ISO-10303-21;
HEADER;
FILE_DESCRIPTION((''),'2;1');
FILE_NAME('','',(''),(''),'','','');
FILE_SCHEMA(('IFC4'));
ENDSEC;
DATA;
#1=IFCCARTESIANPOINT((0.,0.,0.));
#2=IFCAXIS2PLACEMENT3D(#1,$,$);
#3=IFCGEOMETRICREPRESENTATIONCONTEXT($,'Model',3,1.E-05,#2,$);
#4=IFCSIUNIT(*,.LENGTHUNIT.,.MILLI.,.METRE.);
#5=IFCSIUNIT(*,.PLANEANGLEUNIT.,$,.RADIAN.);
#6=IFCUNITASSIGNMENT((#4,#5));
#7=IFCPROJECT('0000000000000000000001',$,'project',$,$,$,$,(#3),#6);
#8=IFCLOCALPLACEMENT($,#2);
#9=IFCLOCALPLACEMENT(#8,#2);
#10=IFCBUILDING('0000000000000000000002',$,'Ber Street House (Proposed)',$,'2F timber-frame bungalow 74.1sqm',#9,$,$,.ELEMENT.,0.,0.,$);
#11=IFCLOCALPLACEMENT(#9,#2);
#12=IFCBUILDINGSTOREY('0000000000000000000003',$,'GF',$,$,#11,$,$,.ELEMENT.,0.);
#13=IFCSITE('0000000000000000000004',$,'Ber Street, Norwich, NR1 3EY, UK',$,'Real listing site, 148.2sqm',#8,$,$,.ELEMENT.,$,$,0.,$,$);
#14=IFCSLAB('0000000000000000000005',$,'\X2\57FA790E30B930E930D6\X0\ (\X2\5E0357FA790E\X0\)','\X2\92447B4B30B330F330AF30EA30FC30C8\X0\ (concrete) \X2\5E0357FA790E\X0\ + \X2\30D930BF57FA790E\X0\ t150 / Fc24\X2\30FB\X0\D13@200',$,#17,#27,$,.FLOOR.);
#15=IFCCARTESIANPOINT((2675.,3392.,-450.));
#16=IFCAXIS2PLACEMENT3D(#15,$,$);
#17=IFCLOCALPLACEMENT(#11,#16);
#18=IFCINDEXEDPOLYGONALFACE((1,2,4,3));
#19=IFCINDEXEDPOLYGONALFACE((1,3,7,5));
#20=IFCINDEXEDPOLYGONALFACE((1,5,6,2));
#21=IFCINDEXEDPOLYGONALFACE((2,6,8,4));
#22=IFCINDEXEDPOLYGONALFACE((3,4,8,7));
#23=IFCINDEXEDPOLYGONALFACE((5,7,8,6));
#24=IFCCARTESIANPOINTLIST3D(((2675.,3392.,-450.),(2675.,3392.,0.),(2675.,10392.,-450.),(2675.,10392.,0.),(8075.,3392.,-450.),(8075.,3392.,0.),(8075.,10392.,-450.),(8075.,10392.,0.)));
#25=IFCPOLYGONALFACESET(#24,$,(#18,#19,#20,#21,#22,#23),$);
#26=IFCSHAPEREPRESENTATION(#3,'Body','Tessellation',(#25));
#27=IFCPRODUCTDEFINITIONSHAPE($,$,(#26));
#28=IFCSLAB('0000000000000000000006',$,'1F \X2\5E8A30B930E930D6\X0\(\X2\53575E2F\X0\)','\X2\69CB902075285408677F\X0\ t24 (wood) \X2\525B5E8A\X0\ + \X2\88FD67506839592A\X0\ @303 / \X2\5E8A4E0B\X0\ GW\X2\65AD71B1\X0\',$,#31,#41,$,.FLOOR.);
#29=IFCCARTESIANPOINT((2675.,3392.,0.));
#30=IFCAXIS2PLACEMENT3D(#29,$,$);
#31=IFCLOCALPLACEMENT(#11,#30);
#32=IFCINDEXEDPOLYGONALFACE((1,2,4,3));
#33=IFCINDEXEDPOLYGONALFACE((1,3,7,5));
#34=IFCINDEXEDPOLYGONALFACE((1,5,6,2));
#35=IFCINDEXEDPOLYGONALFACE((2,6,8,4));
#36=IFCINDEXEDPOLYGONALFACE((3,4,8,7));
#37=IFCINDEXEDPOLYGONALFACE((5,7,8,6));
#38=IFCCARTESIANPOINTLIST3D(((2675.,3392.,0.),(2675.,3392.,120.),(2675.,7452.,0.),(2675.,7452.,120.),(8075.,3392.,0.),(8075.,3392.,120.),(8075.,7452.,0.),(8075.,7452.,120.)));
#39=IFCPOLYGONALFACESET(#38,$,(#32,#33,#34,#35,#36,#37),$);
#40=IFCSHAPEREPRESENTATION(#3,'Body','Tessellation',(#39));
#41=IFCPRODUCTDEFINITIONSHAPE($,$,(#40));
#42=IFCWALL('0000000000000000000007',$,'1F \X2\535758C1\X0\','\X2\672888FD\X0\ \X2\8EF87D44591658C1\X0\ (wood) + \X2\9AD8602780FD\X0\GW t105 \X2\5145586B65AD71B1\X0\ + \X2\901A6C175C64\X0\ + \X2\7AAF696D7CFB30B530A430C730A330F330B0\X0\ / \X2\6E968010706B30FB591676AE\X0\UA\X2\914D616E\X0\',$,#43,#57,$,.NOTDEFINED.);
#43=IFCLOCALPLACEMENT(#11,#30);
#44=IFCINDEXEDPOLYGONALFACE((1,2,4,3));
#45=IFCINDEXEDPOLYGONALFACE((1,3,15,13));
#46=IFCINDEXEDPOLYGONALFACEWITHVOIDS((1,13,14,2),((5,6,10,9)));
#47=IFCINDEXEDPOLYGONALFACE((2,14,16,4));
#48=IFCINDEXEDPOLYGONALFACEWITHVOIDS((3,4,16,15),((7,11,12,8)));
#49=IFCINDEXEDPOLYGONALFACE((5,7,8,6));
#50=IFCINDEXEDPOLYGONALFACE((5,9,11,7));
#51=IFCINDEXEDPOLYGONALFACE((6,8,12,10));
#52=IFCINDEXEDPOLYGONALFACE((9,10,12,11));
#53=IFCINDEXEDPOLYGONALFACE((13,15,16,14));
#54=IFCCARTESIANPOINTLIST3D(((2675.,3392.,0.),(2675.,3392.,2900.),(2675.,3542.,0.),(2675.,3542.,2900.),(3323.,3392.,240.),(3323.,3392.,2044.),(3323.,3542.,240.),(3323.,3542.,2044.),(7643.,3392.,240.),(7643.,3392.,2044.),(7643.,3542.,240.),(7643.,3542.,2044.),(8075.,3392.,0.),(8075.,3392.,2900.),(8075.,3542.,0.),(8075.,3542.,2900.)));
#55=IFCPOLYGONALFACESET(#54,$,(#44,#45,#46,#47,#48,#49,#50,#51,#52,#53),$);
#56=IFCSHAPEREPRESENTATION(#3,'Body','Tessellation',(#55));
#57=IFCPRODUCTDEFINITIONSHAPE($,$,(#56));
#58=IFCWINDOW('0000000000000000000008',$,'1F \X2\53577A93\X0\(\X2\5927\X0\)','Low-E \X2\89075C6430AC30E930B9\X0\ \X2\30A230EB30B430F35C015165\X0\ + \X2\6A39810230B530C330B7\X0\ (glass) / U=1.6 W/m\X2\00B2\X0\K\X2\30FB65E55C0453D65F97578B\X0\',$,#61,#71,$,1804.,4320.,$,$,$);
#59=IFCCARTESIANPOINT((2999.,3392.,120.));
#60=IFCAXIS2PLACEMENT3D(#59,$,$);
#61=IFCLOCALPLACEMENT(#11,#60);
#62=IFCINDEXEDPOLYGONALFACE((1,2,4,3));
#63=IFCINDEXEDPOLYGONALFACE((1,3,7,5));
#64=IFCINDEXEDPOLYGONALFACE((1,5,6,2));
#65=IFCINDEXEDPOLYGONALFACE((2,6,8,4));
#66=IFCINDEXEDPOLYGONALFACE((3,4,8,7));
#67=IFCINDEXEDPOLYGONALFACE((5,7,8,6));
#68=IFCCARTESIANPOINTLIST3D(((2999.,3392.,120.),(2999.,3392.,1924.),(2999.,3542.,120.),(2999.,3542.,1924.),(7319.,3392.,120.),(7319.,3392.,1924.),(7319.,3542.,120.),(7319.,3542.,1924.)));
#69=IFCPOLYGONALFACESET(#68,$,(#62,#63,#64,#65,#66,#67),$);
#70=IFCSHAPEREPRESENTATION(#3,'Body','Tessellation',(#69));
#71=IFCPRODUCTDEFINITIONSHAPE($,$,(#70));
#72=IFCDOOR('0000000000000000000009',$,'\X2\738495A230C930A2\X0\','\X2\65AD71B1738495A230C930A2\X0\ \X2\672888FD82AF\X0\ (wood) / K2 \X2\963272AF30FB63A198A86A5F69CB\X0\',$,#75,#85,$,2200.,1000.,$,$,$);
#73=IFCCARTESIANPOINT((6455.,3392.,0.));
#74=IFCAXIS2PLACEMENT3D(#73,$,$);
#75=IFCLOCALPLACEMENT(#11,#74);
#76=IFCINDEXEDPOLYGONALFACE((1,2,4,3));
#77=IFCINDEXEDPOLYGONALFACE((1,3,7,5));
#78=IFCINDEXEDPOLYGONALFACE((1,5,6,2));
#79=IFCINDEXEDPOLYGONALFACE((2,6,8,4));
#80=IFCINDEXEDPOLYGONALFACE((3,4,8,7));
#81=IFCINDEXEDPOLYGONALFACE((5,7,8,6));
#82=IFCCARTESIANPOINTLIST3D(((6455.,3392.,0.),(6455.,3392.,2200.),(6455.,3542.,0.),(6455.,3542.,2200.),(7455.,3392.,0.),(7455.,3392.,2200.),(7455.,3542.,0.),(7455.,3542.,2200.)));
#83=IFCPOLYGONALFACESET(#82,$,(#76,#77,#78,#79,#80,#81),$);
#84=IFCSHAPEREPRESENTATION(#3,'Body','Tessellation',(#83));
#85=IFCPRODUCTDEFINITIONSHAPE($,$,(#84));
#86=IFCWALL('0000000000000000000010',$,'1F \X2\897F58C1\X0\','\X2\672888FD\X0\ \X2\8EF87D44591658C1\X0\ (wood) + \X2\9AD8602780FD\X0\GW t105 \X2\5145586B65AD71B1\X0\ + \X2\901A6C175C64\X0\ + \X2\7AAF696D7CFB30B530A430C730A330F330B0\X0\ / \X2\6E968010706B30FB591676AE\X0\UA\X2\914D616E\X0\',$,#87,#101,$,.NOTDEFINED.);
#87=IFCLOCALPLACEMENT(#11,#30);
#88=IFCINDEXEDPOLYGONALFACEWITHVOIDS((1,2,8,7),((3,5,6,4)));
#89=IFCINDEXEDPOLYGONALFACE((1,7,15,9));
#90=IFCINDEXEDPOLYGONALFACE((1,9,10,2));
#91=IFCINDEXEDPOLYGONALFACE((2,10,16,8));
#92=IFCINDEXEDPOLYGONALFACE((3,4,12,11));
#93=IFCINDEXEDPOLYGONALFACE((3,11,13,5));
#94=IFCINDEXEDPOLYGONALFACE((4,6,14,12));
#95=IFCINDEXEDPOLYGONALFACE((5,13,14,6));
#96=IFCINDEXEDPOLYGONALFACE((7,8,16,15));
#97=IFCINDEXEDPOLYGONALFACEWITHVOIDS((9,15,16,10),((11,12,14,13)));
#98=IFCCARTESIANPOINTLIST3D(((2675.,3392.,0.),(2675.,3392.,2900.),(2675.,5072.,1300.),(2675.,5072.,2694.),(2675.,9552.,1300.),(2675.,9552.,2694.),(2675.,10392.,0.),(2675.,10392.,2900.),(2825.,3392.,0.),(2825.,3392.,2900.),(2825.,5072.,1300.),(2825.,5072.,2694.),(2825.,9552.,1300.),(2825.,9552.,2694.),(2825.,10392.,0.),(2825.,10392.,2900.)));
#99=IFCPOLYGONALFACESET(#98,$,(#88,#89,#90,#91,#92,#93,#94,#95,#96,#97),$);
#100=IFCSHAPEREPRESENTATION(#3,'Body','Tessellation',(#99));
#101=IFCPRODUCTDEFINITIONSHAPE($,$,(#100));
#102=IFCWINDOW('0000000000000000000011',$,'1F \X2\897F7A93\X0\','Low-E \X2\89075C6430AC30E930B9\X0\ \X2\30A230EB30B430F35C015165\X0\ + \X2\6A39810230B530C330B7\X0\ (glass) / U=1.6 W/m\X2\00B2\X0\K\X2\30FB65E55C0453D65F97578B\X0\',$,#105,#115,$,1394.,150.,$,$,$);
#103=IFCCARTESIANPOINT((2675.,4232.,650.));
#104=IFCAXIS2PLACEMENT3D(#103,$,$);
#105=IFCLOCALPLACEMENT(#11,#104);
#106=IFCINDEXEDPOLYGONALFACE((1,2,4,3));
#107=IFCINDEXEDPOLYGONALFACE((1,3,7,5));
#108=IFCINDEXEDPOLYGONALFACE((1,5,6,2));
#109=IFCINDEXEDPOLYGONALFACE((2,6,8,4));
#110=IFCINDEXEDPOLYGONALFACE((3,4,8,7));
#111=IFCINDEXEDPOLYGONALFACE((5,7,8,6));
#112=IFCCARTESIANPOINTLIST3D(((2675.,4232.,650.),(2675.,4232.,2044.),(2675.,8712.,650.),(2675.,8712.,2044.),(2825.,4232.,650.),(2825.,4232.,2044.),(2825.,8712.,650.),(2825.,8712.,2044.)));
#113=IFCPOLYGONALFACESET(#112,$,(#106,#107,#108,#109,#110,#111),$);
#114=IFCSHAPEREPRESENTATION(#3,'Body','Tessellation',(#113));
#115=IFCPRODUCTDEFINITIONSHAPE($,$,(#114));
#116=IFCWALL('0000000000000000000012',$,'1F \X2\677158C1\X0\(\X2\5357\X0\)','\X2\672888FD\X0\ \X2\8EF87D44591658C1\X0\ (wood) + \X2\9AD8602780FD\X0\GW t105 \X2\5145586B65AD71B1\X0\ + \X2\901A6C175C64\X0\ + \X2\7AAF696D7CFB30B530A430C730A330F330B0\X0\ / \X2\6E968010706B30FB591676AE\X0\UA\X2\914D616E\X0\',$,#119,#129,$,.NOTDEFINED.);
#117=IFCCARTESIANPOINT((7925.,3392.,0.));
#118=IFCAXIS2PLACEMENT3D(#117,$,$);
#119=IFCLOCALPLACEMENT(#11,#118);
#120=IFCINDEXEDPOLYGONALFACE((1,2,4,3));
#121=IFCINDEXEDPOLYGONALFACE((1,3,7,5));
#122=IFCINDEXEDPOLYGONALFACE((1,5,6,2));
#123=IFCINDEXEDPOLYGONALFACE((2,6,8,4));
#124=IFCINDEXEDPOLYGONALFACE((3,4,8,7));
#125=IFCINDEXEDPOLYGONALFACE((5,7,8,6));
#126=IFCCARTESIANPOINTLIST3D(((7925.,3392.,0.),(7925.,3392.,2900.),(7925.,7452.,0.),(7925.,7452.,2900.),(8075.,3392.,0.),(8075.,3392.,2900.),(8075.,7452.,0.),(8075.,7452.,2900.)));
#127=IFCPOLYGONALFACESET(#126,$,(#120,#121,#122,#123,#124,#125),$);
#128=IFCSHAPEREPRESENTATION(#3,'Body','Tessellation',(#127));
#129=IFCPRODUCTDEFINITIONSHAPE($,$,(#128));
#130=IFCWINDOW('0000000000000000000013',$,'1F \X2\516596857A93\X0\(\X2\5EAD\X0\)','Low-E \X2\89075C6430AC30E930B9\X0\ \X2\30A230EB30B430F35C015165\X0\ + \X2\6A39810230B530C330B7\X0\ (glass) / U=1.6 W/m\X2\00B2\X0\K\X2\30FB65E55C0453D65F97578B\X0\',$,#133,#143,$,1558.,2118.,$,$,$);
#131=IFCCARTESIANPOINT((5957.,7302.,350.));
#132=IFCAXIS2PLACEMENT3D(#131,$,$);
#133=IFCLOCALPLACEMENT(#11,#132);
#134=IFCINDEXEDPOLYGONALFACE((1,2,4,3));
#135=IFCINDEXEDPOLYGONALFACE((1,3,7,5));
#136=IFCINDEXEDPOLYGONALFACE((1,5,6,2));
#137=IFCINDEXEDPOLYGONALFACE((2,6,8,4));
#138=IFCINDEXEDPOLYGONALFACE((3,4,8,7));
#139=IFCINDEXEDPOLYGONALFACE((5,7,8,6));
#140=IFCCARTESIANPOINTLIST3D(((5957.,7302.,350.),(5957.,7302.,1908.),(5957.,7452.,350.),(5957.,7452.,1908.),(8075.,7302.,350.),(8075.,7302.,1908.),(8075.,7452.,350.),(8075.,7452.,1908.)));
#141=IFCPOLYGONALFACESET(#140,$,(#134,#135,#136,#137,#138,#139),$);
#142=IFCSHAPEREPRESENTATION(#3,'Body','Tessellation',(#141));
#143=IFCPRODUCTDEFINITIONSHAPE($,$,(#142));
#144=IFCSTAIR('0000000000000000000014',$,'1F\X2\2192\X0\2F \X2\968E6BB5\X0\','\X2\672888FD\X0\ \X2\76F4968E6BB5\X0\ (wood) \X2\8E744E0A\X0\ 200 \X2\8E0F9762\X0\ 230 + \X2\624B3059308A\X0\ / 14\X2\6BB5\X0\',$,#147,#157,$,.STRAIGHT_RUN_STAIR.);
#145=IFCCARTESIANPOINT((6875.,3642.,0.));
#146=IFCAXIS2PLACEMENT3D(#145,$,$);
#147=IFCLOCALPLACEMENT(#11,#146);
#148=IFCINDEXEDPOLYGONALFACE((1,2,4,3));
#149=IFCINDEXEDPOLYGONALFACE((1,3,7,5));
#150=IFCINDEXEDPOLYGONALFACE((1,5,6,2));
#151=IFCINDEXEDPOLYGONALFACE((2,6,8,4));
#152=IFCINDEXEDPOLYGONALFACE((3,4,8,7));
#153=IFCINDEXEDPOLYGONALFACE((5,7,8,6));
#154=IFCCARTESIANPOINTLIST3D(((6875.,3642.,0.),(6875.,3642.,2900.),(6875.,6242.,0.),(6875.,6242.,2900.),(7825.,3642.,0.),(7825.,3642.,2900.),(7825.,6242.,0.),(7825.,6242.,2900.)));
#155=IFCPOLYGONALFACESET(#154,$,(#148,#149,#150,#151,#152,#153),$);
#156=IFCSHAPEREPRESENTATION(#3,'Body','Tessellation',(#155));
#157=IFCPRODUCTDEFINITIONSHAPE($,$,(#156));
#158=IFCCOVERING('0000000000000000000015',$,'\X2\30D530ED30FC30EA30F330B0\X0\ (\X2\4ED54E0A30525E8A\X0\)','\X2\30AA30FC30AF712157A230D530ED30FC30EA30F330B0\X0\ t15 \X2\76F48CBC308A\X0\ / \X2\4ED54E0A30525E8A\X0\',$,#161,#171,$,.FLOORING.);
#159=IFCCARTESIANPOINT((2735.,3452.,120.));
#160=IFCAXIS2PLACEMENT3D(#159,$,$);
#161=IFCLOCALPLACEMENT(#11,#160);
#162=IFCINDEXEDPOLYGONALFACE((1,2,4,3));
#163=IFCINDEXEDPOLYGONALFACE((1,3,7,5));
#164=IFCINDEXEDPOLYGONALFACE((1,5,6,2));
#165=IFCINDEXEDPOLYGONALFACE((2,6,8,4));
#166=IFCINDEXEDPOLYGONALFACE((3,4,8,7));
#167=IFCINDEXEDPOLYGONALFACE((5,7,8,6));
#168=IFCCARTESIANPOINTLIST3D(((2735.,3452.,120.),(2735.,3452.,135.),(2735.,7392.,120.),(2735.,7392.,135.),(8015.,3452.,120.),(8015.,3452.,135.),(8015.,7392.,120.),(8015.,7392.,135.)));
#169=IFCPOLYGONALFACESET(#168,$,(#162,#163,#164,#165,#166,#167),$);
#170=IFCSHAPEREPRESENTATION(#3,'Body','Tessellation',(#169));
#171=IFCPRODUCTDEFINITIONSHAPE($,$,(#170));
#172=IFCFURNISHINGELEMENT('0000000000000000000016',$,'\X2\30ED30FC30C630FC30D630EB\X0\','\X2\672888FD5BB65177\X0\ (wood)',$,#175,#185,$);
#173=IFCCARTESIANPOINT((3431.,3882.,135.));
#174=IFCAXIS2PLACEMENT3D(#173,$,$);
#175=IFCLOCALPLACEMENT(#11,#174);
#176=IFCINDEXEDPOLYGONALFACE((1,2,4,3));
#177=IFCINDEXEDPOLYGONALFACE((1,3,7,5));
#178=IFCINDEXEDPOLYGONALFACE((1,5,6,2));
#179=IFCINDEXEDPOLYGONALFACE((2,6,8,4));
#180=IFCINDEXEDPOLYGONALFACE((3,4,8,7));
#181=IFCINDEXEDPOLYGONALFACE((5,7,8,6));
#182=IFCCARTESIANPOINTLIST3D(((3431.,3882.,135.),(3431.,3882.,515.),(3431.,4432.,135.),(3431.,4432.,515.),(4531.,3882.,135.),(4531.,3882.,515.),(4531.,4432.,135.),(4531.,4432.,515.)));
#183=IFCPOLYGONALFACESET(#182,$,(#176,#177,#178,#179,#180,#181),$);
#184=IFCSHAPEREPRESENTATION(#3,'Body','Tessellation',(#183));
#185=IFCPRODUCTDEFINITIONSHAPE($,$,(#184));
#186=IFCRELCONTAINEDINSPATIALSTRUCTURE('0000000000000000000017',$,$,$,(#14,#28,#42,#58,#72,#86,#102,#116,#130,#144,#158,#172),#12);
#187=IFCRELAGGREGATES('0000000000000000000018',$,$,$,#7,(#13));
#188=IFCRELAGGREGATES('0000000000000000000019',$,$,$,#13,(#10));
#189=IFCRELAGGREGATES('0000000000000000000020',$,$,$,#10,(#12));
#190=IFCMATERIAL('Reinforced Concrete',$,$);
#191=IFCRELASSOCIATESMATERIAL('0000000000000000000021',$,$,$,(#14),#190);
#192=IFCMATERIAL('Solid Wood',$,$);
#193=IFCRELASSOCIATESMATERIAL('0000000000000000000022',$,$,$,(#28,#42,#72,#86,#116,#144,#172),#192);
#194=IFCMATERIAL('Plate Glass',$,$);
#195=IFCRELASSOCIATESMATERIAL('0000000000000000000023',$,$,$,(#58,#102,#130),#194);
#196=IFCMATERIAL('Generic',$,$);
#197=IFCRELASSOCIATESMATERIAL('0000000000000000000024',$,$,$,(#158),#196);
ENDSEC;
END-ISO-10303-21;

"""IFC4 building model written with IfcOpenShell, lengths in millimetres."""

from ifc_helpers import new_model, si_unit, frame, frame_2d, origin, place, context, project, spatial, rectangle, extrude, material, element, fill, save


model = new_model("IFC4")

# Units and contexts
model_context = context("Model", 3, precision=1e-05, world=origin())
ifc_project = project(units=[si_unit("LENGTHUNIT", "METRE", prefix="MILLI"), si_unit("PLANEANGLEUNIT", "RADIAN")], contexts=[model_context])

# Site, building, storey
site_placement = place(None, origin())
site = spatial("IfcSite", under=ifc_project, at=site_placement, Name="Ber Street, Norwich, NR1 3EY, UK", ObjectType="Real listing site, 148.2sqm", CompositionType="ELEMENT", RefElevation=0.0)
building_placement = place(site_placement, origin())
building = spatial("IfcBuilding", under=site, at=building_placement, Name="Ber Street House (Proposed)", ObjectType="2F timber-frame bungalow 74.1sqm", CompositionType="ELEMENT", ElevationOfRefHeight=0.0, ElevationOfTerrain=0.0)
storey_placement = place(building_placement, origin())
storey = spatial("IfcBuildingStorey", under=building, at=storey_placement, Name="GF", CompositionType="ELEMENT", Elevation=0.0)

# Slabs
ifc_material_1 = material(Name="Reinforced Concrete")
slab_1_placement = place(storey_placement, frame((2675.0, 3392.0, -450.0)))
element("IfcSlab", 1, at=slab_1_placement, inside=storey, material=ifc_material_1, Name="基礎スラブ (布基礎)", Description="鉄筋コンクリート (concrete) 布基礎 + ベタ基礎 t150 / Fc24・D13@200", PredefinedType="FLOOR", context=model_context, shape_type="SweptSolid", body=[
    extrude(rectangle(XDim=5400.0, YDim=7000.0, at=frame_2d((2700.0, 3500.0))), frame((2675.0, 3392.0, -450.0)), (0.0, 0.0, 1.0), 450.0),
])
ifc_material_2 = material(Name="Solid Wood")
slab_2_placement = place(storey_placement, frame((2675.0, 3392.0, 0.0)))
element("IfcSlab", 2, at=slab_2_placement, inside=storey, material=ifc_material_2, Name="1F 床スラブ(南帯)", Description="構造用合板 t24 (wood) 剛床 + 製材根太 @303 / 床下 GW断熱", PredefinedType="FLOOR", context=model_context, shape_type="SweptSolid", body=[
    extrude(rectangle(XDim=5400.0, YDim=4060.0, at=frame_2d((2700.0, 2030.0))), frame((2675.0, 3392.0, 0.0)), (0.0, 0.0, 1.0), 120.0),
])

# Wall, openings, window, door
wall_1_placement = place(storey_placement, frame((2675.0, 3392.0, 0.0)))
wall_1 = element("IfcWall", 3, at=wall_1_placement, inside=storey, material=ifc_material_2, Name="1F 南壁", Description="木製 軸組外壁 (wood) + 高性能GW t105 充填断熱 + 通気層 + 窯業系サイディング / 準耐火・外皮UA配慮", PredefinedType="NOTDEFINED", context=model_context, shape_type="SweptSolid", body=[
    extrude(rectangle(XDim=5400.0, YDim=150.0, at=frame_2d((2700.0, 75.0))), frame((2675.0, 3392.0, 0.0)), (0.0, 0.0, 1.0), 2900.0),
])
opening_1_placement = place(storey_placement, frame((2999.0, 3392.0, 120.0)))
opening_1 = element("IfcOpeningElement", 4, at=opening_1_placement, cuts=wall_1, PredefinedType="NOTDEFINED", context=model_context, shape_type="SweptSolid", body=[
    extrude(rectangle(XDim=4320.0, YDim=150.0, at=frame_2d((2160.0, 75.0))), frame((2999.0, 3392.0, 120.0)), (0.0, 0.0, 1.0), 1804.0),
])
opening_2_placement = place(storey_placement, frame((6455.0, 3392.0, 0.0)))
opening_2 = element("IfcOpeningElement", 5, at=opening_2_placement, cuts=wall_1, PredefinedType="NOTDEFINED", context=model_context, shape_type="SweptSolid", body=[
    extrude(rectangle(XDim=1000.0, YDim=150.0, at=frame_2d((500.0, 75.0))), frame((6455.0, 3392.0, 0.0)), (0.0, 0.0, 1.0), 2200.0),
])
ifc_material_3 = material(Name="Plate Glass")
window_1_placement = place(storey_placement, frame((2999.0, 3392.0, 120.0)))
window_1 = element("IfcWindow", 6, at=window_1_placement, inside=storey, material=ifc_material_3, Name="1F 南窓(大)", Description="Low-E 複層ガラス アルゴン封入 + 樹脂サッシ (glass) / U=1.6 W/m²K・日射取得型", OverallHeight=1804.0, OverallWidth=4320.0, context=model_context, shape_type="SweptSolid", body=[
    extrude(rectangle(XDim=4320.0, YDim=150.0, at=frame_2d((2160.0, 75.0))), frame((2999.0, 3392.0, 120.0)), (0.0, 0.0, 1.0), 1804.0),
])
fill(opening_1, window_1)
door_1_placement = place(storey_placement, frame((6455.0, 3392.0, 0.0)))
door_1 = element("IfcDoor", 7, at=door_1_placement, inside=storey, material=ifc_material_2, Name="玄関ドア", Description="断熱玄関ドア 木製芯 (wood) / K2 防犯・採風機構", OverallHeight=2200.0, OverallWidth=1000.0, context=model_context, shape_type="SweptSolid", body=[
    extrude(rectangle(XDim=1000.0, YDim=150.0, at=frame_2d((500.0, 75.0))), frame((6455.0, 3392.0, 0.0)), (0.0, 0.0, 1.0), 2200.0),
])
fill(opening_2, door_1)

# Walls, openings, windows
wall_2_placement = place(storey_placement, frame((2675.0, 3392.0, 0.0)))
wall_2 = element("IfcWall", 8, at=wall_2_placement, inside=storey, material=ifc_material_2, Name="1F 西壁", Description="木製 軸組外壁 (wood) + 高性能GW t105 充填断熱 + 通気層 + 窯業系サイディング / 準耐火・外皮UA配慮", PredefinedType="NOTDEFINED", context=model_context, shape_type="SweptSolid", body=[
    extrude(rectangle(XDim=150.0, YDim=7000.0, at=frame_2d((75.0, 3500.0))), frame((2675.0, 3392.0, 0.0)), (0.0, 0.0, 1.0), 2900.0),
])
opening_3_placement = place(storey_placement, frame((2675.0, 4232.0, 650.0)))
opening_3 = element("IfcOpeningElement", 9, at=opening_3_placement, cuts=wall_2, PredefinedType="NOTDEFINED", context=model_context, shape_type="SweptSolid", body=[
    extrude(rectangle(XDim=150.0, YDim=4480.0, at=frame_2d((75.0, 2240.0))), frame((2675.0, 4232.0, 650.0)), (0.0, 0.0, 1.0), 1394.0),
])
window_2_placement = place(storey_placement, frame((2675.0, 4232.0, 650.0)))
window_2 = element("IfcWindow", 10, at=window_2_placement, inside=storey, material=ifc_material_3, Name="1F 西窓", Description="Low-E 複層ガラス アルゴン封入 + 樹脂サッシ (glass) / U=1.6 W/m²K・日射取得型", OverallHeight=1394.0, OverallWidth=150.0, context=model_context, shape_type="SweptSolid", body=[
    extrude(rectangle(XDim=150.0, YDim=4480.0, at=frame_2d((75.0, 2240.0))), frame((2675.0, 4232.0, 650.0)), (0.0, 0.0, 1.0), 1394.0),
])
fill(opening_3, window_2)
wall_3_placement = place(storey_placement, frame((7925.0, 3392.0, 0.0)))
wall_3 = element("IfcWall", 11, at=wall_3_placement, inside=storey, material=ifc_material_2, Name="1F 東壁(南)", Description="木製 軸組外壁 (wood) + 高性能GW t105 充填断熱 + 通気層 + 窯業系サイディング / 準耐火・外皮UA配慮", PredefinedType="NOTDEFINED", context=model_context, shape_type="SweptSolid", body=[
    extrude(rectangle(XDim=150.0, YDim=4060.0, at=frame_2d((75.0, 2030.0))), frame((7925.0, 3392.0, 0.0)), (0.0, 0.0, 1.0), 2900.0),
])
opening_4_placement = place(storey_placement, frame((5957.0, 7302.0, 350.0)))
opening_4 = element("IfcOpeningElement", 12, at=opening_4_placement, cuts=wall_3, PredefinedType="NOTDEFINED", context=model_context, shape_type="SweptSolid", body=[
    extrude(rectangle(XDim=2118.0, YDim=150.0, at=frame_2d((1059.0, 75.0))), frame((5957.0, 7302.0, 350.0)), (0.0, 0.0, 1.0), 1558.0),
])
window_3_placement = place(storey_placement, frame((5957.0, 7302.0, 350.0)))
window_3 = element("IfcWindow", 13, at=window_3_placement, inside=storey, material=ifc_material_3, Name="1F 入隅窓(庭)", Description="Low-E 複層ガラス アルゴン封入 + 樹脂サッシ (glass) / U=1.6 W/m²K・日射取得型", OverallHeight=1558.0, OverallWidth=2118.0, context=model_context, shape_type="SweptSolid", body=[
    extrude(rectangle(XDim=2118.0, YDim=150.0, at=frame_2d((1059.0, 75.0))), frame((5957.0, 7302.0, 350.0)), (0.0, 0.0, 1.0), 1558.0),
])
fill(opening_4, window_3)

# Stair
stair_placement = place(storey_placement, frame((6875.0, 3642.0, 0.0)))
element("IfcStair", 14, at=stair_placement, inside=storey, material=ifc_material_2, Name="1F→2F 階段", Description="木製 直階段 (wood) 蹴上 200 踏面 230 + 手すり / 14段", PredefinedType="STRAIGHT_RUN_STAIR", context=model_context, shape_type="SweptSolid", body=[
    extrude(rectangle(XDim=950.0, YDim=2600.0, at=frame_2d((475.0, 1300.0))), frame((6875.0, 3642.0, 0.0)), (0.0, 0.0, 1.0), 2900.0),
])

# Covering
ifc_material_4 = material(Name="Generic")
covering_placement = place(storey_placement, frame((2735.0, 3452.0, 120.0)))
element("IfcCovering", 15, at=covering_placement, inside=storey, material=ifc_material_4, Name="フローリング (仕上げ床)", Description="オーク無垢フローリング t15 直貼り / 仕上げ床", PredefinedType="FLOORING", context=model_context, shape_type="SweptSolid", body=[
    extrude(rectangle(XDim=5280.0, YDim=3940.0, at=frame_2d((2640.0, 1970.0))), frame((2735.0, 3452.0, 120.0)), (0.0, 0.0, 1.0), 15.0),
])

# Furnishing element
furnishing_1_placement = place(storey_placement, frame((3431.0, 3882.0, 135.0)))
element("IfcFurnishingElement", 16, at=furnishing_1_placement, inside=storey, material=ifc_material_2, Name="ローテーブル", Description="木製家具 (wood)", context=model_context, shape_type="SweptSolid", body=[
    extrude(rectangle(XDim=1100.0, YDim=550.0, at=frame_2d((550.0, 275.0))), frame((3431.0, 3882.0, 135.0)), (0.0, 0.0, 1.0), 380.0),
])

save(model, "model.ifc")
